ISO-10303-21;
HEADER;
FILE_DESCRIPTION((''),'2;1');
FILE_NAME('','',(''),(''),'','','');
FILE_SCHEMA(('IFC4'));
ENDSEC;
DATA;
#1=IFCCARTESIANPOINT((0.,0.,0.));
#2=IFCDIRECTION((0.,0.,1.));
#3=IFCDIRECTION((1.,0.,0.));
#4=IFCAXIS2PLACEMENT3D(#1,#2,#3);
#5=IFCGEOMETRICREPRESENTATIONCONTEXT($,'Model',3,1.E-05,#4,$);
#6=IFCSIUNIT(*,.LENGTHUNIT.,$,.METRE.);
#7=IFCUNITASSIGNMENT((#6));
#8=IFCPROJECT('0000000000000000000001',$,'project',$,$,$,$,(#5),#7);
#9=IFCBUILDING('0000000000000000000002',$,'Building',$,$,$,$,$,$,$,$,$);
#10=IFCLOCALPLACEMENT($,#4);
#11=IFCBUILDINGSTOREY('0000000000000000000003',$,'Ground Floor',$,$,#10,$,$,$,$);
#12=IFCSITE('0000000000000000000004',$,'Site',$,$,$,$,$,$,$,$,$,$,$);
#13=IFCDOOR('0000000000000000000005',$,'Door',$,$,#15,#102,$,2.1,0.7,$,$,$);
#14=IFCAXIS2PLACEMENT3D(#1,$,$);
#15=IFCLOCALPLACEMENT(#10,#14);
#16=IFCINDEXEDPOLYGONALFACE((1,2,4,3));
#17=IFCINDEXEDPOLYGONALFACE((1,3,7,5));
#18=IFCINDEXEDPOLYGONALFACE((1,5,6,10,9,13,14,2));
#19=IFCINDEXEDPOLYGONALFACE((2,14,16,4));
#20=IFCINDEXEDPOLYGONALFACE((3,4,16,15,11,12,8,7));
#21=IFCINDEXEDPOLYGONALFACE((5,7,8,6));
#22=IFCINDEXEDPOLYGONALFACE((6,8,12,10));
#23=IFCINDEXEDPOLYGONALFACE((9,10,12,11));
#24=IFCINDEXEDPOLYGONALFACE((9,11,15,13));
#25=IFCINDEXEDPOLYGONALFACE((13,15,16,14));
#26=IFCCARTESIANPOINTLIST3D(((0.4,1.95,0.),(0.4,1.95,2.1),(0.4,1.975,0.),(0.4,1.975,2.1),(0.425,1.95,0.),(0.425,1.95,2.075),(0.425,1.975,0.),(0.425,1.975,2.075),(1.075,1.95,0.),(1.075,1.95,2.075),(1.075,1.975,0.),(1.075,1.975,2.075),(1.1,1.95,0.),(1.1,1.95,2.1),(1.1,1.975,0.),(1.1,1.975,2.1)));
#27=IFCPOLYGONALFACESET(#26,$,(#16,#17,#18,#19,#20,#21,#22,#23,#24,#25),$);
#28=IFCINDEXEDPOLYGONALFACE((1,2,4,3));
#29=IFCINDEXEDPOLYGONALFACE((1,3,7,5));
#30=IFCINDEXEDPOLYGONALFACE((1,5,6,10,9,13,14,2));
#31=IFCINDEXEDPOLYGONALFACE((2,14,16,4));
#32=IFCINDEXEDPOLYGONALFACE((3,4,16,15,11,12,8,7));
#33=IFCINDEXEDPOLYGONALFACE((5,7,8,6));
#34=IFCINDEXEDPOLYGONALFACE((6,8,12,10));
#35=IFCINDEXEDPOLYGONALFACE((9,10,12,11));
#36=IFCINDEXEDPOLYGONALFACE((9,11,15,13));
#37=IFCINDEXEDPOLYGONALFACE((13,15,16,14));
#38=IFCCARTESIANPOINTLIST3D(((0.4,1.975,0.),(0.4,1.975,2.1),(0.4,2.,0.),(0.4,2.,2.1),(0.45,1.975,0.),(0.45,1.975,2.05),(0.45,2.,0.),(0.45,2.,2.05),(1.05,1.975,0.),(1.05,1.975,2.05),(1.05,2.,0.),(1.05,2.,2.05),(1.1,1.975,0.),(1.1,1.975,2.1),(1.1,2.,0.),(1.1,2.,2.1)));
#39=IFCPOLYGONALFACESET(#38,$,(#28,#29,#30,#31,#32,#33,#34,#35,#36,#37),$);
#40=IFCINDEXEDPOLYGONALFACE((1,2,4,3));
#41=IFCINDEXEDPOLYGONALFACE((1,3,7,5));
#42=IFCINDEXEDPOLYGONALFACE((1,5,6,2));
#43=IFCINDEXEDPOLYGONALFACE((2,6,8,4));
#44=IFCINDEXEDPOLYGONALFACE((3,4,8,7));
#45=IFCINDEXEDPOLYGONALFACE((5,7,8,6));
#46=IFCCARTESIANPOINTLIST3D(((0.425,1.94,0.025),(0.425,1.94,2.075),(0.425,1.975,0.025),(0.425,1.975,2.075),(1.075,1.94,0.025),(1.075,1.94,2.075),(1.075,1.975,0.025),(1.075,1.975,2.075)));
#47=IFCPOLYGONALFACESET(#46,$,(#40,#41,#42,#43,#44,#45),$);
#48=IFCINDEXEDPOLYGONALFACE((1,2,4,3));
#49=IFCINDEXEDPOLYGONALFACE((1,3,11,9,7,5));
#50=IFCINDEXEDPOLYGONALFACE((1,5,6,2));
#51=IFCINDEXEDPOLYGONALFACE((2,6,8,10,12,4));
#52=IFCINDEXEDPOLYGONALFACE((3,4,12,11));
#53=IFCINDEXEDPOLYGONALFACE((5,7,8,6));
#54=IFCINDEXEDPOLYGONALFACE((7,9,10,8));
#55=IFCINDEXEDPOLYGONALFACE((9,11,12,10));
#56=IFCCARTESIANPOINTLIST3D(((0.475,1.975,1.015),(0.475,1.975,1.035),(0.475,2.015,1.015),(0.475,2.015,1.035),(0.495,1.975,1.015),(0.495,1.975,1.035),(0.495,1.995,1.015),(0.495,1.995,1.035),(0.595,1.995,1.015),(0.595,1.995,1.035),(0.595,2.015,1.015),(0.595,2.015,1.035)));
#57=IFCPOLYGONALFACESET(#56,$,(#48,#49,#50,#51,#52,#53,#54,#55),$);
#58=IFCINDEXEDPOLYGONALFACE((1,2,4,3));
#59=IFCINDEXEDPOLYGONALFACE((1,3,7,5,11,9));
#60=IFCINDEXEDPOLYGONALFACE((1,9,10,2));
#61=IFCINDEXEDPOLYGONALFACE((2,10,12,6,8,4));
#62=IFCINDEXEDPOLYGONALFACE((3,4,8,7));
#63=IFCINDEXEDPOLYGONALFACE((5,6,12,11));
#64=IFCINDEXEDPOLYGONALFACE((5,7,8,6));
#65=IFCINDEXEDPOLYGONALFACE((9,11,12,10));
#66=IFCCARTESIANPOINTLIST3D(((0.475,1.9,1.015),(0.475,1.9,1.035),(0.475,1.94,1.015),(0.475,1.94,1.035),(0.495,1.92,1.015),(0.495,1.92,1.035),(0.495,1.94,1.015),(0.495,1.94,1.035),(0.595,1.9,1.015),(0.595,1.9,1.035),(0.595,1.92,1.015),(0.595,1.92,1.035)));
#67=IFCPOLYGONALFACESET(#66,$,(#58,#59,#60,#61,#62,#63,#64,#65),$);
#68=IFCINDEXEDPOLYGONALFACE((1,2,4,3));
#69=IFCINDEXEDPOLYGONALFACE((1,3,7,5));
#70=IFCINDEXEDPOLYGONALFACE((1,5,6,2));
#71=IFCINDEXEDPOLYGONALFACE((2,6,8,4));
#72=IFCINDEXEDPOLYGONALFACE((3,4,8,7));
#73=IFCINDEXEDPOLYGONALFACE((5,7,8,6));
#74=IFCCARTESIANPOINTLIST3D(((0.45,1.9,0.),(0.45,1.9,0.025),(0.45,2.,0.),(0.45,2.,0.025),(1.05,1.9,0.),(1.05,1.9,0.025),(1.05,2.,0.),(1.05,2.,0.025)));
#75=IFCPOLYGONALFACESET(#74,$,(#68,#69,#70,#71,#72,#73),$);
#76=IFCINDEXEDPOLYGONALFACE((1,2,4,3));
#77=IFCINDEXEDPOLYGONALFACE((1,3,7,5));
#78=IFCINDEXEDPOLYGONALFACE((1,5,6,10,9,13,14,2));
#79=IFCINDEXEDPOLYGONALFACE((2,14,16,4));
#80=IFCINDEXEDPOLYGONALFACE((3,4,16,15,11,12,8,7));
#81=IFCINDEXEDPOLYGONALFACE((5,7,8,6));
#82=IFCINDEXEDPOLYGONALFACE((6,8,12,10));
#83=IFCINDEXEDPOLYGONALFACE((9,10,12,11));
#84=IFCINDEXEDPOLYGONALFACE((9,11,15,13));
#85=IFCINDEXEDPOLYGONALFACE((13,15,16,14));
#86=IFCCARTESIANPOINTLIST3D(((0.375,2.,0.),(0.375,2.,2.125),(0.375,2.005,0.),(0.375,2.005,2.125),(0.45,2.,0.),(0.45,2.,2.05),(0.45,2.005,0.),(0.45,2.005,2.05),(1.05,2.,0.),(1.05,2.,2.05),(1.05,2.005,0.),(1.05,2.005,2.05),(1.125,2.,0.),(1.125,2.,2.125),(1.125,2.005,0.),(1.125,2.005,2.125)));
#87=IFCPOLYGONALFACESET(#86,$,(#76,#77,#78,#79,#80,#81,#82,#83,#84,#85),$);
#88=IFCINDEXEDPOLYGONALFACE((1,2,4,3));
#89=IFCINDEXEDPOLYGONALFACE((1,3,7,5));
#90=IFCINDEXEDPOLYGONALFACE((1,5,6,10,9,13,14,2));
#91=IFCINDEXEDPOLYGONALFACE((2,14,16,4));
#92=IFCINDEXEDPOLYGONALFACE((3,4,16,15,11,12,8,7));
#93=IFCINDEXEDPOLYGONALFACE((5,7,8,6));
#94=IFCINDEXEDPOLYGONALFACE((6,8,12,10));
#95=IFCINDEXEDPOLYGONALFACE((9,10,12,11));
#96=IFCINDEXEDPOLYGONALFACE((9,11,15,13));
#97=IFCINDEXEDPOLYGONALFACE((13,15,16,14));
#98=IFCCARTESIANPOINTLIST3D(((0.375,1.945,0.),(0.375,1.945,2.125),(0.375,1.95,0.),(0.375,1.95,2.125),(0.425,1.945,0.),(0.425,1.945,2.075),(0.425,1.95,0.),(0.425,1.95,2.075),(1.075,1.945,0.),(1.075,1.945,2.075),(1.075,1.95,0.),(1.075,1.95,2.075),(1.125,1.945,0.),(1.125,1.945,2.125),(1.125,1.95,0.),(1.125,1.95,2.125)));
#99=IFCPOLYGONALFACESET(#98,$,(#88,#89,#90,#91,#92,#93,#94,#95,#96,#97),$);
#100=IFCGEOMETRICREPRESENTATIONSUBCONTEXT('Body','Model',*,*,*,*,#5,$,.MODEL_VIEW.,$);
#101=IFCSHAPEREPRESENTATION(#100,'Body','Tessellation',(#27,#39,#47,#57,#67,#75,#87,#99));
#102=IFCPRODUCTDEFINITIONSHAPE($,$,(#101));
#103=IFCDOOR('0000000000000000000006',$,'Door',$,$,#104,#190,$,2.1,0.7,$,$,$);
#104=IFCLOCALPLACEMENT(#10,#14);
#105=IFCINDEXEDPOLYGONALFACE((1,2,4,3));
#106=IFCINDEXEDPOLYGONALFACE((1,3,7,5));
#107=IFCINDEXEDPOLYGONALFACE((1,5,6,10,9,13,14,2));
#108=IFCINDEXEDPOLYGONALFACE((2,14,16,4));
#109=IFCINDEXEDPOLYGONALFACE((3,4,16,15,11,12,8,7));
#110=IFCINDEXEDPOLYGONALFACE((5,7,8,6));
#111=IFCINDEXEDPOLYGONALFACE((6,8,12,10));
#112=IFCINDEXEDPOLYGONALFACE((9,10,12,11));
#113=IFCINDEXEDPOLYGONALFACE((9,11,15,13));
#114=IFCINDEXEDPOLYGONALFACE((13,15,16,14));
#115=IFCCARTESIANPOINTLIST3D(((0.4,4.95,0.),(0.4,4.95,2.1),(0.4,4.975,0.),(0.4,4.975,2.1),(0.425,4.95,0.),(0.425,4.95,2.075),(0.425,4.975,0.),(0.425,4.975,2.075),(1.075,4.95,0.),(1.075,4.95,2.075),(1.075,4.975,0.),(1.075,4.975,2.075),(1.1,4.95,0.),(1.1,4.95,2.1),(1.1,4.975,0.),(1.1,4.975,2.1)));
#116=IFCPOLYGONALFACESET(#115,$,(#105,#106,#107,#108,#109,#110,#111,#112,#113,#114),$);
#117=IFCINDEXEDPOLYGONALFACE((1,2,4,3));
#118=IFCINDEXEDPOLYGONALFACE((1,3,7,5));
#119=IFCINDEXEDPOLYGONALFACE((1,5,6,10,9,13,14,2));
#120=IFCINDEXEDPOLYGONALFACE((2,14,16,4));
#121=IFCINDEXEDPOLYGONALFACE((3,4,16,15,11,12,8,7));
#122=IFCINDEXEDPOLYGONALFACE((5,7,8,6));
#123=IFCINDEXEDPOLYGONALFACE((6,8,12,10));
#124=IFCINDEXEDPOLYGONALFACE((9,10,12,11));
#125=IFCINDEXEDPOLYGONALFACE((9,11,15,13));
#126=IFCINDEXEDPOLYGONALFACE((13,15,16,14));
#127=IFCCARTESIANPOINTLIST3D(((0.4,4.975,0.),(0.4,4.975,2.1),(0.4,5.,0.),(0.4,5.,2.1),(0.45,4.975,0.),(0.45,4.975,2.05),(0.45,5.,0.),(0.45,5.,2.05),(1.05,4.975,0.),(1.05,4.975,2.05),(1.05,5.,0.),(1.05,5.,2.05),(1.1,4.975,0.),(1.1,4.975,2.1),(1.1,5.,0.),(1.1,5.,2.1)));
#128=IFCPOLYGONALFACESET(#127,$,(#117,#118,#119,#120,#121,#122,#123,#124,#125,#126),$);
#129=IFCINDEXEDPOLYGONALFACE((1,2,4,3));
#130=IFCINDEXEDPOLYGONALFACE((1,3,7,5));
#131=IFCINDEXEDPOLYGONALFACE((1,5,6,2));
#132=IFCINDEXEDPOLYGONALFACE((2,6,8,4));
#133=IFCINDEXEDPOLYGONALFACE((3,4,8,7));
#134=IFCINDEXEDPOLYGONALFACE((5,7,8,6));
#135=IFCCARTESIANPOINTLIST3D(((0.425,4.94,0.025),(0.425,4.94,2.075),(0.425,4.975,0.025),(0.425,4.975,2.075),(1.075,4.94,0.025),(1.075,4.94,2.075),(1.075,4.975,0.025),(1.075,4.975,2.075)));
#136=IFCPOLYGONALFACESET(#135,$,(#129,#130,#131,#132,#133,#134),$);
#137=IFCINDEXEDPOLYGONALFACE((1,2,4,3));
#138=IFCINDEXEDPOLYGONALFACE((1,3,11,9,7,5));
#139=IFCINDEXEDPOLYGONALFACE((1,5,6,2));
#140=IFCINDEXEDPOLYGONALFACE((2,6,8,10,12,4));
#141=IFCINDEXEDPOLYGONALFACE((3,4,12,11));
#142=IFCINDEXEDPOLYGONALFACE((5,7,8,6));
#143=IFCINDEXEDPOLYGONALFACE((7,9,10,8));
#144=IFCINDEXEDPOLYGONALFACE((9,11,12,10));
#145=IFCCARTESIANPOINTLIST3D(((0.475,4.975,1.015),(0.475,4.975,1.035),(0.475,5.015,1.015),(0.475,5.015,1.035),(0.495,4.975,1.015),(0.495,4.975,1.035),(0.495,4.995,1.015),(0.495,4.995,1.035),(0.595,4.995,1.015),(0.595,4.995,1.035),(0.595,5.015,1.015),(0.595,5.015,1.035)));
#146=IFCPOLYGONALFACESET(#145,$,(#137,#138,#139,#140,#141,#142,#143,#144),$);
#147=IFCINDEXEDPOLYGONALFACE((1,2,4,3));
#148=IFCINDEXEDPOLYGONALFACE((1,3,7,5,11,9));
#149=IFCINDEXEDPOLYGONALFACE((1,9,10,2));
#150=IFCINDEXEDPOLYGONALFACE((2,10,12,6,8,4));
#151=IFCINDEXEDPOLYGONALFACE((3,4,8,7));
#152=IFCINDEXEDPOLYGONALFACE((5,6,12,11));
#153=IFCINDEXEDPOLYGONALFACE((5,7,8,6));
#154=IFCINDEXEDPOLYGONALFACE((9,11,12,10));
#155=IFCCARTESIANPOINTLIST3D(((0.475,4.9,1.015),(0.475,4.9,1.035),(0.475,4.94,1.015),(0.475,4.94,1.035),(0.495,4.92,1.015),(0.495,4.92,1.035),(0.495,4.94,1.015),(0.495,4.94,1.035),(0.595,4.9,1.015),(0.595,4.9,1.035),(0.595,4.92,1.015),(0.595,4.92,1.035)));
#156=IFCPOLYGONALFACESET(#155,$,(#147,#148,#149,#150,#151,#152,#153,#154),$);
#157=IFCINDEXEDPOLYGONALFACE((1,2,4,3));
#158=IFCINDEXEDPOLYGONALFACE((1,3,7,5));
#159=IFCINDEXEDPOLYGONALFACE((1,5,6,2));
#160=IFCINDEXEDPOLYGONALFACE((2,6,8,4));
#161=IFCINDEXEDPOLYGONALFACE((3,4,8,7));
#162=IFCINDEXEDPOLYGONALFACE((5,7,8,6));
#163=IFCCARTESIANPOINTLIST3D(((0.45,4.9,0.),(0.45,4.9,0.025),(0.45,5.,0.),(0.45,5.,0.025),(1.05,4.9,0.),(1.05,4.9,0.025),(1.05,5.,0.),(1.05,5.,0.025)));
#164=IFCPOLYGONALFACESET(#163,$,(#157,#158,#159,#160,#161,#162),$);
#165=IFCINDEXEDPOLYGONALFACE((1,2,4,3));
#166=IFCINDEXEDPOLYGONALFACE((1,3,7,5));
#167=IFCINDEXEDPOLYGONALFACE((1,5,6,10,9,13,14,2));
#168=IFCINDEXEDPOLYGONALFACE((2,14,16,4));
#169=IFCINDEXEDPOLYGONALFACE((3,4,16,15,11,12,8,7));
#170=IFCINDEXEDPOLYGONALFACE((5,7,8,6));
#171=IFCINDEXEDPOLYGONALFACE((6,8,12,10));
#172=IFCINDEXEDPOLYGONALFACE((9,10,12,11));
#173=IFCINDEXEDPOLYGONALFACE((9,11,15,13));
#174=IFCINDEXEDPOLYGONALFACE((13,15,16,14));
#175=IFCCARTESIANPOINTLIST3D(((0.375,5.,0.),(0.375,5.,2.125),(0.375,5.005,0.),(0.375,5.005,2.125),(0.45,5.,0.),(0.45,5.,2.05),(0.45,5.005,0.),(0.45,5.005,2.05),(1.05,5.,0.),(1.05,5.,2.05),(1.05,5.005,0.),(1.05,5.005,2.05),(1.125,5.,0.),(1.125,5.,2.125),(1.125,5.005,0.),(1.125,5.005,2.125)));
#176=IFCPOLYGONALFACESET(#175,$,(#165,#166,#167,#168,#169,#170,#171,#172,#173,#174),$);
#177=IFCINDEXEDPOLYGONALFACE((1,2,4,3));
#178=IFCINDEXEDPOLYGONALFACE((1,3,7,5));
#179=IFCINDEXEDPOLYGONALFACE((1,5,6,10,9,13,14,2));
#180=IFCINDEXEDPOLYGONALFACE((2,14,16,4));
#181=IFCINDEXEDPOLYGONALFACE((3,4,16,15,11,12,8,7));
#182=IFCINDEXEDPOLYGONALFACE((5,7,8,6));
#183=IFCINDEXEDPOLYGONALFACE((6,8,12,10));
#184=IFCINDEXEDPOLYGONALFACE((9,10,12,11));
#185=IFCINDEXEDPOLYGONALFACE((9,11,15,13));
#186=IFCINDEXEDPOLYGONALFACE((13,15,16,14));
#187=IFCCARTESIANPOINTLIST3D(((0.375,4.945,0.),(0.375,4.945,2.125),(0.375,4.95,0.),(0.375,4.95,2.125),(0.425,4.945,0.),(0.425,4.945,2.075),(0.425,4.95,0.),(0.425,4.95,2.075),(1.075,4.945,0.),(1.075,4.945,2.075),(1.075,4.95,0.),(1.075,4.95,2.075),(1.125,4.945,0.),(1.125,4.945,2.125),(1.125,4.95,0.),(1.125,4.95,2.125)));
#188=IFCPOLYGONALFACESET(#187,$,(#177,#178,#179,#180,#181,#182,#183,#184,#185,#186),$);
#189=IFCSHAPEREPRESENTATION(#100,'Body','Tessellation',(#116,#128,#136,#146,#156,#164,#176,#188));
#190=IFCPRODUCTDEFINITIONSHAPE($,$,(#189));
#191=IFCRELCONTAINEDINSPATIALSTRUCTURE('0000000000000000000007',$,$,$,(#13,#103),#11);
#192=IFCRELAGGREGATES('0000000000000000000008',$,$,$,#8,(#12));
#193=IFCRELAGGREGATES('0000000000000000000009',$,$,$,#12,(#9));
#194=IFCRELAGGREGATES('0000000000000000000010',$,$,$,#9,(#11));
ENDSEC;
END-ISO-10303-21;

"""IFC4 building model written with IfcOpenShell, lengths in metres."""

from ifc_helpers import new_model, si_unit, frame, origin_with_axes, place, context, subcontext, project, spatial, line, indexed_curve, outline, extrude, element, save


model = new_model("IFC4")

# Units and contexts
model_context = context("Model", 3, precision=1e-05, world=origin_with_axes())
body_context = subcontext(model_context, "Body", "Model", "MODEL_VIEW")
ifc_project = project(units=[si_unit("LENGTHUNIT", "METRE")], contexts=[model_context])

# Site, building, storey
site = spatial("IfcSite", under=ifc_project, Name="Site")
building = spatial("IfcBuilding", under=site, Name="Building")
storey_placement = place(None, origin_with_axes())
storey = spatial("IfcBuildingStorey", under=building, at=storey_placement, Name="Ground Floor")

# Doors
door_1_placement = place(storey_placement, frame((1.1, 2.0, 0.0), z_axis=(0.0, 0.0, 1.0), x_axis=(-1.0, 0.0, 0.0)))
element("IfcDoor", 1, at=door_1_placement, inside=storey, Name="Door", OverallHeight=2.1, OverallWidth=0.7, context=body_context, shape_type="SweptSolid", body=[
    extrude(outline(indexed_curve([(0.0, 0.0), (0.0, 2.1), (0.7, 2.1), (0.7, 0.0), (0.675, 0.0), (0.675, 2.075), (0.025, 2.075), (0.025, 0.0)], segments=[line(1, 2, 3, 4, 5, 6, 7, 8, 1)])), frame((0.0, 0.025, 0.0), z_axis=(0.0, -1.0, 0.0), x_axis=(1.0, 0.0, 0.0)), (0.0, 0.0, -1.0), 0.025),
    extrude(outline(indexed_curve([(0.0, 0.0), (0.0, 2.1), (0.7, 2.1), (0.7, 0.0), (0.65, 0.0), (0.65, 2.05), (0.05, 2.05), (0.05, 0.0)], segments=[line(1, 2, 3, 4, 5, 6, 7, 8, 1)])), frame((0.0, 0.0, 0.0), z_axis=(0.0, -1.0, 0.0), x_axis=(1.0, 0.0, 0.0)), (0.0, 0.0, -1.0), 0.025),
    extrude(outline(indexed_curve([(0.0, 0.0), (0.65, 0.0), (0.65, 0.035), (0.0, 0.035)], segments=[line(1, 2, 3, 4, 1)])), frame((0.025, 0.025, 0.025), z_axis=(0.0, 0.0, 1.0), x_axis=(1.0, 0.0, 0.0)), (0.0, 0.0, 1.0), 2.05),
    extrude(outline(indexed_curve([(0.0, 0.0), (0.0, -0.04), (-0.12, -0.04), (-0.12, -0.02), (-0.02, -0.02), (-0.02, 0.0)], segments=[line(1, 2, 3, 4, 5, 6, 1)])), frame((0.625, 0.025, 1.015), z_axis=(0.0, 0.0, 1.0), x_axis=(1.0, 0.0, 0.0)), (0.0, 0.0, 1.0), 0.02),
    extrude(outline(indexed_curve([(0.0, 0.0), (0.0, 0.04), (-0.12, 0.04), (-0.12, 0.02), (-0.02, 0.02), (-0.02, 0.0)], segments=[line(1, 2, 3, 4, 5, 6, 1)])), frame((0.625, 0.06, 1.015), z_axis=(0.0, 0.0, 1.0), x_axis=(1.0, 0.0, 0.0)), (0.0, 0.0, 1.0), 0.02),
    extrude(outline(indexed_curve([(0.0, 0.0), (0.6, 0.0), (0.6, 0.1), (0.0, 0.1)], segments=[line(1, 2, 3, 4, 1)])), frame((0.05, 0.0, 0.0), z_axis=(0.0, 0.0, 1.0), x_axis=(1.0, 0.0, 0.0)), (0.0, 0.0, 1.0), 0.025),
    extrude(outline(indexed_curve([(0.0, 0.0), (0.0, 2.125), (0.75, 2.125), (0.75, 0.0), (0.675, 0.0), (0.675, 2.05), (0.075, 2.05), (0.075, 0.0)], segments=[line(1, 2, 3, 4, 5, 6, 7, 8, 1)])), frame((-0.025, -0.005, 0.0), z_axis=(0.0, -1.0, 0.0), x_axis=(1.0, 0.0, 0.0)), (0.0, 0.0, -1.0), 0.005),
    extrude(outline(indexed_curve([(0.0, 0.0), (0.0, 2.125), (0.75, 2.125), (0.75, 0.0), (0.7, 0.0), (0.7, 2.075), (0.05, 2.075), (0.05, 0.0)], segments=[line(1, 2, 3, 4, 5, 6, 7, 8, 1)])), frame((-0.025, 0.05, 0.0), z_axis=(0.0, -1.0, 0.0), x_axis=(1.0, 0.0, 0.0)), (0.0, 0.0, -1.0), 0.005),
])
door_2_placement = place(storey_placement, frame((1.1, 5.0, 0.0), z_axis=(0.0, 0.0, 1.0), x_axis=(-1.0, 0.0, 0.0)))
element("IfcDoor", 2, at=door_2_placement, inside=storey, Name="Door", OverallHeight=2.1, OverallWidth=0.7, context=body_context, shape_type="SweptSolid", body=[
    extrude(outline(indexed_curve([(0.0, 0.0), (0.0, 2.1), (0.7, 2.1), (0.7, 0.0), (0.675, 0.0), (0.675, 2.075), (0.025, 2.075), (0.025, 0.0)], segments=[line(1, 2, 3, 4, 5, 6, 7, 8, 1)])), frame((0.0, 0.025, 0.0), z_axis=(0.0, -1.0, 0.0), x_axis=(1.0, 0.0, 0.0)), (0.0, 0.0, -1.0), 0.025),
    extrude(outline(indexed_curve([(0.0, 0.0), (0.0, 2.1), (0.7, 2.1), (0.7, 0.0), (0.65, 0.0), (0.65, 2.05), (0.05, 2.05), (0.05, 0.0)], segments=[line(1, 2, 3, 4, 5, 6, 7, 8, 1)])), frame((0.0, 0.0, 0.0), z_axis=(0.0, -1.0, 0.0), x_axis=(1.0, 0.0, 0.0)), (0.0, 0.0, -1.0), 0.025),
    extrude(outline(indexed_curve([(0.0, 0.0), (0.65, 0.0), (0.65, 0.035), (0.0, 0.035)], segments=[line(1, 2, 3, 4, 1)])), frame((0.025, 0.025, 0.025), z_axis=(0.0, 0.0, 1.0), x_axis=(1.0, 0.0, 0.0)), (0.0, 0.0, 1.0), 2.05),
    extrude(outline(indexed_curve([(0.0, 0.0), (0.0, -0.04), (-0.12, -0.04), (-0.12, -0.02), (-0.02, -0.02), (-0.02, 0.0)], segments=[line(1, 2, 3, 4, 5, 6, 1)])), frame((0.625, 0.025, 1.015), z_axis=(0.0, 0.0, 1.0), x_axis=(1.0, 0.0, 0.0)), (0.0, 0.0, 1.0), 0.02),
    extrude(outline(indexed_curve([(0.0, 0.0), (0.0, 0.04), (-0.12, 0.04), (-0.12, 0.02), (-0.02, 0.02), (-0.02, 0.0)], segments=[line(1, 2, 3, 4, 5, 6, 1)])), frame((0.625, 0.06, 1.015), z_axis=(0.0, 0.0, 1.0), x_axis=(1.0, 0.0, 0.0)), (0.0, 0.0, 1.0), 0.02),
    extrude(outline(indexed_curve([(0.0, 0.0), (0.6, 0.0), (0.6, 0.1), (0.0, 0.1)], segments=[line(1, 2, 3, 4, 1)])), frame((0.05, 0.0, 0.0), z_axis=(0.0, 0.0, 1.0), x_axis=(1.0, 0.0, 0.0)), (0.0, 0.0, 1.0), 0.025),
    extrude(outline(indexed_curve([(0.0, 0.0), (0.0, 2.125), (0.75, 2.125), (0.75, 0.0), (0.675, 0.0), (0.675, 2.05), (0.075, 2.05), (0.075, 0.0)], segments=[line(1, 2, 3, 4, 5, 6, 7, 8, 1)])), frame((-0.025, -0.005, 0.0), z_axis=(0.0, -1.0, 0.0), x_axis=(1.0, 0.0, 0.0)), (0.0, 0.0, -1.0), 0.005),
    extrude(outline(indexed_curve([(0.0, 0.0), (0.0, 2.125), (0.75, 2.125), (0.75, 0.0), (0.7, 0.0), (0.7, 2.075), (0.05, 2.075), (0.05, 0.0)], segments=[line(1, 2, 3, 4, 5, 6, 7, 8, 1)])), frame((-0.025, 0.05, 0.0), z_axis=(0.0, -1.0, 0.0), x_axis=(1.0, 0.0, 0.0)), (0.0, 0.0, -1.0), 0.005),
])

save(model, "model.ifc")
